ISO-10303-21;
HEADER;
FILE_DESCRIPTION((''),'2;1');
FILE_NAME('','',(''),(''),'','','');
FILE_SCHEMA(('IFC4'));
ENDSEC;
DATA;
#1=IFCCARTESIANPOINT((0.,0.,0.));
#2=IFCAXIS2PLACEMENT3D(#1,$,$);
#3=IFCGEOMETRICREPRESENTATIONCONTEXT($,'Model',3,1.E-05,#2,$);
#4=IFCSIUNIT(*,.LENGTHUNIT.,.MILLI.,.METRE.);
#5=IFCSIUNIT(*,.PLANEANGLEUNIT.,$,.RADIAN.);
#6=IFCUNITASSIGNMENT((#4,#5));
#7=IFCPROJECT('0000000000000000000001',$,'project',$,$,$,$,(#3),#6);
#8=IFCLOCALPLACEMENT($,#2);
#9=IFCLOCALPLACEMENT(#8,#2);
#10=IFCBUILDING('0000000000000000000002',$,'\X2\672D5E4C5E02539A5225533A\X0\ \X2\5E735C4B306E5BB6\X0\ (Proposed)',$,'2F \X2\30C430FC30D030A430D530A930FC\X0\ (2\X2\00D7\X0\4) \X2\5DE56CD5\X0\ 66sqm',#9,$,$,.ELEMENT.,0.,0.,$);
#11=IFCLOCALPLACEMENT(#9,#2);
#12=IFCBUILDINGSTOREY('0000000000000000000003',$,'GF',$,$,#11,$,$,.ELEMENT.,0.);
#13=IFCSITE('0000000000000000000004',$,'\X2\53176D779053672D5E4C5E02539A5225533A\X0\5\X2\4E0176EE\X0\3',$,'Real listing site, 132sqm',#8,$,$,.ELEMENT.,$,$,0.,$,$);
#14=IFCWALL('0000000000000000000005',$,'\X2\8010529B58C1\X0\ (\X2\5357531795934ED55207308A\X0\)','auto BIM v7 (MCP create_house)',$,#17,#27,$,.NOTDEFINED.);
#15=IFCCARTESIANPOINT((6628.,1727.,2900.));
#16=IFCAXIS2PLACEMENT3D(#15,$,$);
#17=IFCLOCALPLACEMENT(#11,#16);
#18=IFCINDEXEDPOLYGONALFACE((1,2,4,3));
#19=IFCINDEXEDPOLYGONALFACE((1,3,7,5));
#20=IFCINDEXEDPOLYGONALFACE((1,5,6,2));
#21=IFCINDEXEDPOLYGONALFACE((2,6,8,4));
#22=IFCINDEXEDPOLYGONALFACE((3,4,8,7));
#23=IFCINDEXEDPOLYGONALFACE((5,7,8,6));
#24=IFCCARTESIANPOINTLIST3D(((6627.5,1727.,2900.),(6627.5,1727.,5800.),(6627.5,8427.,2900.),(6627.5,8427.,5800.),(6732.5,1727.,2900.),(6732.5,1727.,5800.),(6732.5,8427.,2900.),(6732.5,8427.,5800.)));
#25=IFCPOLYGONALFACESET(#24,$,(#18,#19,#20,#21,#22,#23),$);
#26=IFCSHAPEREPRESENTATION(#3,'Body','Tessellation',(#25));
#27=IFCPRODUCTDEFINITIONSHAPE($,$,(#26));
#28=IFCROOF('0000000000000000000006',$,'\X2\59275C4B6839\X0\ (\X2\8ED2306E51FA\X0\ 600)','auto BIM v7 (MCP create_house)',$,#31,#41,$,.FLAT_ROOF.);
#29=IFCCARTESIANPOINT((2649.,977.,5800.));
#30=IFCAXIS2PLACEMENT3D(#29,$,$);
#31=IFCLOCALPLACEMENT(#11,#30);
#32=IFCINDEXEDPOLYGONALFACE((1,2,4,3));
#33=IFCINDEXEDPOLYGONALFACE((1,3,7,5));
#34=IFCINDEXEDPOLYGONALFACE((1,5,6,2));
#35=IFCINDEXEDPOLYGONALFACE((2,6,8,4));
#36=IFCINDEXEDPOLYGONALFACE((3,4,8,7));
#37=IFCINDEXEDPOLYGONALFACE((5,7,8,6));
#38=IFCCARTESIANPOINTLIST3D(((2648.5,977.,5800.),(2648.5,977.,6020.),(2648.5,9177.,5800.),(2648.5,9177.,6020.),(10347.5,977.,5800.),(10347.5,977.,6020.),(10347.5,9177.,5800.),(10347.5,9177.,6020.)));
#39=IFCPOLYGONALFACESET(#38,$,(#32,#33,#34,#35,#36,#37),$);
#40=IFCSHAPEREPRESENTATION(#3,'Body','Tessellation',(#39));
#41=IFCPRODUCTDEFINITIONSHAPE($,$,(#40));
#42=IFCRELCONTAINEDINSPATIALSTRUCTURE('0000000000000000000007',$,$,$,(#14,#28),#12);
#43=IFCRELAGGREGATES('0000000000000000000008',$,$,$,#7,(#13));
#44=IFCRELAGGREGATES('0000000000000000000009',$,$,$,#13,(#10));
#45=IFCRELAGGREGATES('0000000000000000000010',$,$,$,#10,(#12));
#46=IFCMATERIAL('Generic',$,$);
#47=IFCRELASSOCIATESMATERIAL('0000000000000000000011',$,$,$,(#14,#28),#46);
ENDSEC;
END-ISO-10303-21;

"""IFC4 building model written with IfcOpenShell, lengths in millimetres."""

from ifc_helpers import new_model, si_unit, frame, frame_2d, origin, place, context, project, spatial, rectangle, extrude, material, element, save


model = new_model("IFC4")

# Units and contexts
model_context = context("Model", 3, precision=1e-05, world=origin())
ifc_project = project(units=[si_unit("LENGTHUNIT", "METRE", prefix="MILLI"), si_unit("PLANEANGLEUNIT", "RADIAN")], contexts=[model_context])

# Site, building, storey
site_placement = place(None, origin())
site = spatial("IfcSite", under=ifc_project, at=site_placement, Name="北海道札幌市厚別区5丁目3", ObjectType="Real listing site, 132sqm", CompositionType="ELEMENT", RefElevation=0.0)
building_placement = place(site_placement, origin())
building = spatial("IfcBuilding", under=site, at=building_placement, Name="札幌市厚別区 平屋の家 (Proposed)", ObjectType="2F ツーバイフォー (2×4) 工法 66sqm", CompositionType="ELEMENT", ElevationOfRefHeight=0.0, ElevationOfTerrain=0.0)
storey_placement = place(building_placement, origin())
storey = spatial("IfcBuildingStorey", under=building, at=storey_placement, Name="GF", CompositionType="ELEMENT", Elevation=0.0)

# Shared definitions
ifc_material = material(Name="Generic")

# Wall
wall_1_placement = place(storey_placement, frame((6628.0, 1727.0, 2900.0)))
element("IfcWall", 1, at=wall_1_placement, inside=storey, material=ifc_material, Name="耐力壁 (南北間仕切り)", Description="auto BIM v7 (MCP create_house)", PredefinedType="NOTDEFINED", context=model_context, shape_type="SweptSolid", body=[
    extrude(rectangle(XDim=105.0, YDim=6700.0, at=frame_2d((52.0, 3350.0))), frame((6628.0, 1727.0, 2900.0)), (0.0, 0.0, 1.0), 2900.0),
])

# Roof
roof_placement = place(storey_placement, frame((2649.0, 977.0, 5800.0)))
element("IfcRoof", 2, at=roof_placement, inside=storey, material=ifc_material, Name="大屋根 (軒の出 600)", Description="auto BIM v7 (MCP create_house)", PredefinedType="FLAT_ROOF", context=model_context, shape_type="SweptSolid", body=[
    extrude(rectangle(XDim=7699.0, YDim=8200.0, at=frame_2d((3849.0, 4100.0))), frame((2649.0, 977.0, 5800.0)), (0.0, 0.0, 1.0), 220.0),
])

save(model, "model.ifc")
